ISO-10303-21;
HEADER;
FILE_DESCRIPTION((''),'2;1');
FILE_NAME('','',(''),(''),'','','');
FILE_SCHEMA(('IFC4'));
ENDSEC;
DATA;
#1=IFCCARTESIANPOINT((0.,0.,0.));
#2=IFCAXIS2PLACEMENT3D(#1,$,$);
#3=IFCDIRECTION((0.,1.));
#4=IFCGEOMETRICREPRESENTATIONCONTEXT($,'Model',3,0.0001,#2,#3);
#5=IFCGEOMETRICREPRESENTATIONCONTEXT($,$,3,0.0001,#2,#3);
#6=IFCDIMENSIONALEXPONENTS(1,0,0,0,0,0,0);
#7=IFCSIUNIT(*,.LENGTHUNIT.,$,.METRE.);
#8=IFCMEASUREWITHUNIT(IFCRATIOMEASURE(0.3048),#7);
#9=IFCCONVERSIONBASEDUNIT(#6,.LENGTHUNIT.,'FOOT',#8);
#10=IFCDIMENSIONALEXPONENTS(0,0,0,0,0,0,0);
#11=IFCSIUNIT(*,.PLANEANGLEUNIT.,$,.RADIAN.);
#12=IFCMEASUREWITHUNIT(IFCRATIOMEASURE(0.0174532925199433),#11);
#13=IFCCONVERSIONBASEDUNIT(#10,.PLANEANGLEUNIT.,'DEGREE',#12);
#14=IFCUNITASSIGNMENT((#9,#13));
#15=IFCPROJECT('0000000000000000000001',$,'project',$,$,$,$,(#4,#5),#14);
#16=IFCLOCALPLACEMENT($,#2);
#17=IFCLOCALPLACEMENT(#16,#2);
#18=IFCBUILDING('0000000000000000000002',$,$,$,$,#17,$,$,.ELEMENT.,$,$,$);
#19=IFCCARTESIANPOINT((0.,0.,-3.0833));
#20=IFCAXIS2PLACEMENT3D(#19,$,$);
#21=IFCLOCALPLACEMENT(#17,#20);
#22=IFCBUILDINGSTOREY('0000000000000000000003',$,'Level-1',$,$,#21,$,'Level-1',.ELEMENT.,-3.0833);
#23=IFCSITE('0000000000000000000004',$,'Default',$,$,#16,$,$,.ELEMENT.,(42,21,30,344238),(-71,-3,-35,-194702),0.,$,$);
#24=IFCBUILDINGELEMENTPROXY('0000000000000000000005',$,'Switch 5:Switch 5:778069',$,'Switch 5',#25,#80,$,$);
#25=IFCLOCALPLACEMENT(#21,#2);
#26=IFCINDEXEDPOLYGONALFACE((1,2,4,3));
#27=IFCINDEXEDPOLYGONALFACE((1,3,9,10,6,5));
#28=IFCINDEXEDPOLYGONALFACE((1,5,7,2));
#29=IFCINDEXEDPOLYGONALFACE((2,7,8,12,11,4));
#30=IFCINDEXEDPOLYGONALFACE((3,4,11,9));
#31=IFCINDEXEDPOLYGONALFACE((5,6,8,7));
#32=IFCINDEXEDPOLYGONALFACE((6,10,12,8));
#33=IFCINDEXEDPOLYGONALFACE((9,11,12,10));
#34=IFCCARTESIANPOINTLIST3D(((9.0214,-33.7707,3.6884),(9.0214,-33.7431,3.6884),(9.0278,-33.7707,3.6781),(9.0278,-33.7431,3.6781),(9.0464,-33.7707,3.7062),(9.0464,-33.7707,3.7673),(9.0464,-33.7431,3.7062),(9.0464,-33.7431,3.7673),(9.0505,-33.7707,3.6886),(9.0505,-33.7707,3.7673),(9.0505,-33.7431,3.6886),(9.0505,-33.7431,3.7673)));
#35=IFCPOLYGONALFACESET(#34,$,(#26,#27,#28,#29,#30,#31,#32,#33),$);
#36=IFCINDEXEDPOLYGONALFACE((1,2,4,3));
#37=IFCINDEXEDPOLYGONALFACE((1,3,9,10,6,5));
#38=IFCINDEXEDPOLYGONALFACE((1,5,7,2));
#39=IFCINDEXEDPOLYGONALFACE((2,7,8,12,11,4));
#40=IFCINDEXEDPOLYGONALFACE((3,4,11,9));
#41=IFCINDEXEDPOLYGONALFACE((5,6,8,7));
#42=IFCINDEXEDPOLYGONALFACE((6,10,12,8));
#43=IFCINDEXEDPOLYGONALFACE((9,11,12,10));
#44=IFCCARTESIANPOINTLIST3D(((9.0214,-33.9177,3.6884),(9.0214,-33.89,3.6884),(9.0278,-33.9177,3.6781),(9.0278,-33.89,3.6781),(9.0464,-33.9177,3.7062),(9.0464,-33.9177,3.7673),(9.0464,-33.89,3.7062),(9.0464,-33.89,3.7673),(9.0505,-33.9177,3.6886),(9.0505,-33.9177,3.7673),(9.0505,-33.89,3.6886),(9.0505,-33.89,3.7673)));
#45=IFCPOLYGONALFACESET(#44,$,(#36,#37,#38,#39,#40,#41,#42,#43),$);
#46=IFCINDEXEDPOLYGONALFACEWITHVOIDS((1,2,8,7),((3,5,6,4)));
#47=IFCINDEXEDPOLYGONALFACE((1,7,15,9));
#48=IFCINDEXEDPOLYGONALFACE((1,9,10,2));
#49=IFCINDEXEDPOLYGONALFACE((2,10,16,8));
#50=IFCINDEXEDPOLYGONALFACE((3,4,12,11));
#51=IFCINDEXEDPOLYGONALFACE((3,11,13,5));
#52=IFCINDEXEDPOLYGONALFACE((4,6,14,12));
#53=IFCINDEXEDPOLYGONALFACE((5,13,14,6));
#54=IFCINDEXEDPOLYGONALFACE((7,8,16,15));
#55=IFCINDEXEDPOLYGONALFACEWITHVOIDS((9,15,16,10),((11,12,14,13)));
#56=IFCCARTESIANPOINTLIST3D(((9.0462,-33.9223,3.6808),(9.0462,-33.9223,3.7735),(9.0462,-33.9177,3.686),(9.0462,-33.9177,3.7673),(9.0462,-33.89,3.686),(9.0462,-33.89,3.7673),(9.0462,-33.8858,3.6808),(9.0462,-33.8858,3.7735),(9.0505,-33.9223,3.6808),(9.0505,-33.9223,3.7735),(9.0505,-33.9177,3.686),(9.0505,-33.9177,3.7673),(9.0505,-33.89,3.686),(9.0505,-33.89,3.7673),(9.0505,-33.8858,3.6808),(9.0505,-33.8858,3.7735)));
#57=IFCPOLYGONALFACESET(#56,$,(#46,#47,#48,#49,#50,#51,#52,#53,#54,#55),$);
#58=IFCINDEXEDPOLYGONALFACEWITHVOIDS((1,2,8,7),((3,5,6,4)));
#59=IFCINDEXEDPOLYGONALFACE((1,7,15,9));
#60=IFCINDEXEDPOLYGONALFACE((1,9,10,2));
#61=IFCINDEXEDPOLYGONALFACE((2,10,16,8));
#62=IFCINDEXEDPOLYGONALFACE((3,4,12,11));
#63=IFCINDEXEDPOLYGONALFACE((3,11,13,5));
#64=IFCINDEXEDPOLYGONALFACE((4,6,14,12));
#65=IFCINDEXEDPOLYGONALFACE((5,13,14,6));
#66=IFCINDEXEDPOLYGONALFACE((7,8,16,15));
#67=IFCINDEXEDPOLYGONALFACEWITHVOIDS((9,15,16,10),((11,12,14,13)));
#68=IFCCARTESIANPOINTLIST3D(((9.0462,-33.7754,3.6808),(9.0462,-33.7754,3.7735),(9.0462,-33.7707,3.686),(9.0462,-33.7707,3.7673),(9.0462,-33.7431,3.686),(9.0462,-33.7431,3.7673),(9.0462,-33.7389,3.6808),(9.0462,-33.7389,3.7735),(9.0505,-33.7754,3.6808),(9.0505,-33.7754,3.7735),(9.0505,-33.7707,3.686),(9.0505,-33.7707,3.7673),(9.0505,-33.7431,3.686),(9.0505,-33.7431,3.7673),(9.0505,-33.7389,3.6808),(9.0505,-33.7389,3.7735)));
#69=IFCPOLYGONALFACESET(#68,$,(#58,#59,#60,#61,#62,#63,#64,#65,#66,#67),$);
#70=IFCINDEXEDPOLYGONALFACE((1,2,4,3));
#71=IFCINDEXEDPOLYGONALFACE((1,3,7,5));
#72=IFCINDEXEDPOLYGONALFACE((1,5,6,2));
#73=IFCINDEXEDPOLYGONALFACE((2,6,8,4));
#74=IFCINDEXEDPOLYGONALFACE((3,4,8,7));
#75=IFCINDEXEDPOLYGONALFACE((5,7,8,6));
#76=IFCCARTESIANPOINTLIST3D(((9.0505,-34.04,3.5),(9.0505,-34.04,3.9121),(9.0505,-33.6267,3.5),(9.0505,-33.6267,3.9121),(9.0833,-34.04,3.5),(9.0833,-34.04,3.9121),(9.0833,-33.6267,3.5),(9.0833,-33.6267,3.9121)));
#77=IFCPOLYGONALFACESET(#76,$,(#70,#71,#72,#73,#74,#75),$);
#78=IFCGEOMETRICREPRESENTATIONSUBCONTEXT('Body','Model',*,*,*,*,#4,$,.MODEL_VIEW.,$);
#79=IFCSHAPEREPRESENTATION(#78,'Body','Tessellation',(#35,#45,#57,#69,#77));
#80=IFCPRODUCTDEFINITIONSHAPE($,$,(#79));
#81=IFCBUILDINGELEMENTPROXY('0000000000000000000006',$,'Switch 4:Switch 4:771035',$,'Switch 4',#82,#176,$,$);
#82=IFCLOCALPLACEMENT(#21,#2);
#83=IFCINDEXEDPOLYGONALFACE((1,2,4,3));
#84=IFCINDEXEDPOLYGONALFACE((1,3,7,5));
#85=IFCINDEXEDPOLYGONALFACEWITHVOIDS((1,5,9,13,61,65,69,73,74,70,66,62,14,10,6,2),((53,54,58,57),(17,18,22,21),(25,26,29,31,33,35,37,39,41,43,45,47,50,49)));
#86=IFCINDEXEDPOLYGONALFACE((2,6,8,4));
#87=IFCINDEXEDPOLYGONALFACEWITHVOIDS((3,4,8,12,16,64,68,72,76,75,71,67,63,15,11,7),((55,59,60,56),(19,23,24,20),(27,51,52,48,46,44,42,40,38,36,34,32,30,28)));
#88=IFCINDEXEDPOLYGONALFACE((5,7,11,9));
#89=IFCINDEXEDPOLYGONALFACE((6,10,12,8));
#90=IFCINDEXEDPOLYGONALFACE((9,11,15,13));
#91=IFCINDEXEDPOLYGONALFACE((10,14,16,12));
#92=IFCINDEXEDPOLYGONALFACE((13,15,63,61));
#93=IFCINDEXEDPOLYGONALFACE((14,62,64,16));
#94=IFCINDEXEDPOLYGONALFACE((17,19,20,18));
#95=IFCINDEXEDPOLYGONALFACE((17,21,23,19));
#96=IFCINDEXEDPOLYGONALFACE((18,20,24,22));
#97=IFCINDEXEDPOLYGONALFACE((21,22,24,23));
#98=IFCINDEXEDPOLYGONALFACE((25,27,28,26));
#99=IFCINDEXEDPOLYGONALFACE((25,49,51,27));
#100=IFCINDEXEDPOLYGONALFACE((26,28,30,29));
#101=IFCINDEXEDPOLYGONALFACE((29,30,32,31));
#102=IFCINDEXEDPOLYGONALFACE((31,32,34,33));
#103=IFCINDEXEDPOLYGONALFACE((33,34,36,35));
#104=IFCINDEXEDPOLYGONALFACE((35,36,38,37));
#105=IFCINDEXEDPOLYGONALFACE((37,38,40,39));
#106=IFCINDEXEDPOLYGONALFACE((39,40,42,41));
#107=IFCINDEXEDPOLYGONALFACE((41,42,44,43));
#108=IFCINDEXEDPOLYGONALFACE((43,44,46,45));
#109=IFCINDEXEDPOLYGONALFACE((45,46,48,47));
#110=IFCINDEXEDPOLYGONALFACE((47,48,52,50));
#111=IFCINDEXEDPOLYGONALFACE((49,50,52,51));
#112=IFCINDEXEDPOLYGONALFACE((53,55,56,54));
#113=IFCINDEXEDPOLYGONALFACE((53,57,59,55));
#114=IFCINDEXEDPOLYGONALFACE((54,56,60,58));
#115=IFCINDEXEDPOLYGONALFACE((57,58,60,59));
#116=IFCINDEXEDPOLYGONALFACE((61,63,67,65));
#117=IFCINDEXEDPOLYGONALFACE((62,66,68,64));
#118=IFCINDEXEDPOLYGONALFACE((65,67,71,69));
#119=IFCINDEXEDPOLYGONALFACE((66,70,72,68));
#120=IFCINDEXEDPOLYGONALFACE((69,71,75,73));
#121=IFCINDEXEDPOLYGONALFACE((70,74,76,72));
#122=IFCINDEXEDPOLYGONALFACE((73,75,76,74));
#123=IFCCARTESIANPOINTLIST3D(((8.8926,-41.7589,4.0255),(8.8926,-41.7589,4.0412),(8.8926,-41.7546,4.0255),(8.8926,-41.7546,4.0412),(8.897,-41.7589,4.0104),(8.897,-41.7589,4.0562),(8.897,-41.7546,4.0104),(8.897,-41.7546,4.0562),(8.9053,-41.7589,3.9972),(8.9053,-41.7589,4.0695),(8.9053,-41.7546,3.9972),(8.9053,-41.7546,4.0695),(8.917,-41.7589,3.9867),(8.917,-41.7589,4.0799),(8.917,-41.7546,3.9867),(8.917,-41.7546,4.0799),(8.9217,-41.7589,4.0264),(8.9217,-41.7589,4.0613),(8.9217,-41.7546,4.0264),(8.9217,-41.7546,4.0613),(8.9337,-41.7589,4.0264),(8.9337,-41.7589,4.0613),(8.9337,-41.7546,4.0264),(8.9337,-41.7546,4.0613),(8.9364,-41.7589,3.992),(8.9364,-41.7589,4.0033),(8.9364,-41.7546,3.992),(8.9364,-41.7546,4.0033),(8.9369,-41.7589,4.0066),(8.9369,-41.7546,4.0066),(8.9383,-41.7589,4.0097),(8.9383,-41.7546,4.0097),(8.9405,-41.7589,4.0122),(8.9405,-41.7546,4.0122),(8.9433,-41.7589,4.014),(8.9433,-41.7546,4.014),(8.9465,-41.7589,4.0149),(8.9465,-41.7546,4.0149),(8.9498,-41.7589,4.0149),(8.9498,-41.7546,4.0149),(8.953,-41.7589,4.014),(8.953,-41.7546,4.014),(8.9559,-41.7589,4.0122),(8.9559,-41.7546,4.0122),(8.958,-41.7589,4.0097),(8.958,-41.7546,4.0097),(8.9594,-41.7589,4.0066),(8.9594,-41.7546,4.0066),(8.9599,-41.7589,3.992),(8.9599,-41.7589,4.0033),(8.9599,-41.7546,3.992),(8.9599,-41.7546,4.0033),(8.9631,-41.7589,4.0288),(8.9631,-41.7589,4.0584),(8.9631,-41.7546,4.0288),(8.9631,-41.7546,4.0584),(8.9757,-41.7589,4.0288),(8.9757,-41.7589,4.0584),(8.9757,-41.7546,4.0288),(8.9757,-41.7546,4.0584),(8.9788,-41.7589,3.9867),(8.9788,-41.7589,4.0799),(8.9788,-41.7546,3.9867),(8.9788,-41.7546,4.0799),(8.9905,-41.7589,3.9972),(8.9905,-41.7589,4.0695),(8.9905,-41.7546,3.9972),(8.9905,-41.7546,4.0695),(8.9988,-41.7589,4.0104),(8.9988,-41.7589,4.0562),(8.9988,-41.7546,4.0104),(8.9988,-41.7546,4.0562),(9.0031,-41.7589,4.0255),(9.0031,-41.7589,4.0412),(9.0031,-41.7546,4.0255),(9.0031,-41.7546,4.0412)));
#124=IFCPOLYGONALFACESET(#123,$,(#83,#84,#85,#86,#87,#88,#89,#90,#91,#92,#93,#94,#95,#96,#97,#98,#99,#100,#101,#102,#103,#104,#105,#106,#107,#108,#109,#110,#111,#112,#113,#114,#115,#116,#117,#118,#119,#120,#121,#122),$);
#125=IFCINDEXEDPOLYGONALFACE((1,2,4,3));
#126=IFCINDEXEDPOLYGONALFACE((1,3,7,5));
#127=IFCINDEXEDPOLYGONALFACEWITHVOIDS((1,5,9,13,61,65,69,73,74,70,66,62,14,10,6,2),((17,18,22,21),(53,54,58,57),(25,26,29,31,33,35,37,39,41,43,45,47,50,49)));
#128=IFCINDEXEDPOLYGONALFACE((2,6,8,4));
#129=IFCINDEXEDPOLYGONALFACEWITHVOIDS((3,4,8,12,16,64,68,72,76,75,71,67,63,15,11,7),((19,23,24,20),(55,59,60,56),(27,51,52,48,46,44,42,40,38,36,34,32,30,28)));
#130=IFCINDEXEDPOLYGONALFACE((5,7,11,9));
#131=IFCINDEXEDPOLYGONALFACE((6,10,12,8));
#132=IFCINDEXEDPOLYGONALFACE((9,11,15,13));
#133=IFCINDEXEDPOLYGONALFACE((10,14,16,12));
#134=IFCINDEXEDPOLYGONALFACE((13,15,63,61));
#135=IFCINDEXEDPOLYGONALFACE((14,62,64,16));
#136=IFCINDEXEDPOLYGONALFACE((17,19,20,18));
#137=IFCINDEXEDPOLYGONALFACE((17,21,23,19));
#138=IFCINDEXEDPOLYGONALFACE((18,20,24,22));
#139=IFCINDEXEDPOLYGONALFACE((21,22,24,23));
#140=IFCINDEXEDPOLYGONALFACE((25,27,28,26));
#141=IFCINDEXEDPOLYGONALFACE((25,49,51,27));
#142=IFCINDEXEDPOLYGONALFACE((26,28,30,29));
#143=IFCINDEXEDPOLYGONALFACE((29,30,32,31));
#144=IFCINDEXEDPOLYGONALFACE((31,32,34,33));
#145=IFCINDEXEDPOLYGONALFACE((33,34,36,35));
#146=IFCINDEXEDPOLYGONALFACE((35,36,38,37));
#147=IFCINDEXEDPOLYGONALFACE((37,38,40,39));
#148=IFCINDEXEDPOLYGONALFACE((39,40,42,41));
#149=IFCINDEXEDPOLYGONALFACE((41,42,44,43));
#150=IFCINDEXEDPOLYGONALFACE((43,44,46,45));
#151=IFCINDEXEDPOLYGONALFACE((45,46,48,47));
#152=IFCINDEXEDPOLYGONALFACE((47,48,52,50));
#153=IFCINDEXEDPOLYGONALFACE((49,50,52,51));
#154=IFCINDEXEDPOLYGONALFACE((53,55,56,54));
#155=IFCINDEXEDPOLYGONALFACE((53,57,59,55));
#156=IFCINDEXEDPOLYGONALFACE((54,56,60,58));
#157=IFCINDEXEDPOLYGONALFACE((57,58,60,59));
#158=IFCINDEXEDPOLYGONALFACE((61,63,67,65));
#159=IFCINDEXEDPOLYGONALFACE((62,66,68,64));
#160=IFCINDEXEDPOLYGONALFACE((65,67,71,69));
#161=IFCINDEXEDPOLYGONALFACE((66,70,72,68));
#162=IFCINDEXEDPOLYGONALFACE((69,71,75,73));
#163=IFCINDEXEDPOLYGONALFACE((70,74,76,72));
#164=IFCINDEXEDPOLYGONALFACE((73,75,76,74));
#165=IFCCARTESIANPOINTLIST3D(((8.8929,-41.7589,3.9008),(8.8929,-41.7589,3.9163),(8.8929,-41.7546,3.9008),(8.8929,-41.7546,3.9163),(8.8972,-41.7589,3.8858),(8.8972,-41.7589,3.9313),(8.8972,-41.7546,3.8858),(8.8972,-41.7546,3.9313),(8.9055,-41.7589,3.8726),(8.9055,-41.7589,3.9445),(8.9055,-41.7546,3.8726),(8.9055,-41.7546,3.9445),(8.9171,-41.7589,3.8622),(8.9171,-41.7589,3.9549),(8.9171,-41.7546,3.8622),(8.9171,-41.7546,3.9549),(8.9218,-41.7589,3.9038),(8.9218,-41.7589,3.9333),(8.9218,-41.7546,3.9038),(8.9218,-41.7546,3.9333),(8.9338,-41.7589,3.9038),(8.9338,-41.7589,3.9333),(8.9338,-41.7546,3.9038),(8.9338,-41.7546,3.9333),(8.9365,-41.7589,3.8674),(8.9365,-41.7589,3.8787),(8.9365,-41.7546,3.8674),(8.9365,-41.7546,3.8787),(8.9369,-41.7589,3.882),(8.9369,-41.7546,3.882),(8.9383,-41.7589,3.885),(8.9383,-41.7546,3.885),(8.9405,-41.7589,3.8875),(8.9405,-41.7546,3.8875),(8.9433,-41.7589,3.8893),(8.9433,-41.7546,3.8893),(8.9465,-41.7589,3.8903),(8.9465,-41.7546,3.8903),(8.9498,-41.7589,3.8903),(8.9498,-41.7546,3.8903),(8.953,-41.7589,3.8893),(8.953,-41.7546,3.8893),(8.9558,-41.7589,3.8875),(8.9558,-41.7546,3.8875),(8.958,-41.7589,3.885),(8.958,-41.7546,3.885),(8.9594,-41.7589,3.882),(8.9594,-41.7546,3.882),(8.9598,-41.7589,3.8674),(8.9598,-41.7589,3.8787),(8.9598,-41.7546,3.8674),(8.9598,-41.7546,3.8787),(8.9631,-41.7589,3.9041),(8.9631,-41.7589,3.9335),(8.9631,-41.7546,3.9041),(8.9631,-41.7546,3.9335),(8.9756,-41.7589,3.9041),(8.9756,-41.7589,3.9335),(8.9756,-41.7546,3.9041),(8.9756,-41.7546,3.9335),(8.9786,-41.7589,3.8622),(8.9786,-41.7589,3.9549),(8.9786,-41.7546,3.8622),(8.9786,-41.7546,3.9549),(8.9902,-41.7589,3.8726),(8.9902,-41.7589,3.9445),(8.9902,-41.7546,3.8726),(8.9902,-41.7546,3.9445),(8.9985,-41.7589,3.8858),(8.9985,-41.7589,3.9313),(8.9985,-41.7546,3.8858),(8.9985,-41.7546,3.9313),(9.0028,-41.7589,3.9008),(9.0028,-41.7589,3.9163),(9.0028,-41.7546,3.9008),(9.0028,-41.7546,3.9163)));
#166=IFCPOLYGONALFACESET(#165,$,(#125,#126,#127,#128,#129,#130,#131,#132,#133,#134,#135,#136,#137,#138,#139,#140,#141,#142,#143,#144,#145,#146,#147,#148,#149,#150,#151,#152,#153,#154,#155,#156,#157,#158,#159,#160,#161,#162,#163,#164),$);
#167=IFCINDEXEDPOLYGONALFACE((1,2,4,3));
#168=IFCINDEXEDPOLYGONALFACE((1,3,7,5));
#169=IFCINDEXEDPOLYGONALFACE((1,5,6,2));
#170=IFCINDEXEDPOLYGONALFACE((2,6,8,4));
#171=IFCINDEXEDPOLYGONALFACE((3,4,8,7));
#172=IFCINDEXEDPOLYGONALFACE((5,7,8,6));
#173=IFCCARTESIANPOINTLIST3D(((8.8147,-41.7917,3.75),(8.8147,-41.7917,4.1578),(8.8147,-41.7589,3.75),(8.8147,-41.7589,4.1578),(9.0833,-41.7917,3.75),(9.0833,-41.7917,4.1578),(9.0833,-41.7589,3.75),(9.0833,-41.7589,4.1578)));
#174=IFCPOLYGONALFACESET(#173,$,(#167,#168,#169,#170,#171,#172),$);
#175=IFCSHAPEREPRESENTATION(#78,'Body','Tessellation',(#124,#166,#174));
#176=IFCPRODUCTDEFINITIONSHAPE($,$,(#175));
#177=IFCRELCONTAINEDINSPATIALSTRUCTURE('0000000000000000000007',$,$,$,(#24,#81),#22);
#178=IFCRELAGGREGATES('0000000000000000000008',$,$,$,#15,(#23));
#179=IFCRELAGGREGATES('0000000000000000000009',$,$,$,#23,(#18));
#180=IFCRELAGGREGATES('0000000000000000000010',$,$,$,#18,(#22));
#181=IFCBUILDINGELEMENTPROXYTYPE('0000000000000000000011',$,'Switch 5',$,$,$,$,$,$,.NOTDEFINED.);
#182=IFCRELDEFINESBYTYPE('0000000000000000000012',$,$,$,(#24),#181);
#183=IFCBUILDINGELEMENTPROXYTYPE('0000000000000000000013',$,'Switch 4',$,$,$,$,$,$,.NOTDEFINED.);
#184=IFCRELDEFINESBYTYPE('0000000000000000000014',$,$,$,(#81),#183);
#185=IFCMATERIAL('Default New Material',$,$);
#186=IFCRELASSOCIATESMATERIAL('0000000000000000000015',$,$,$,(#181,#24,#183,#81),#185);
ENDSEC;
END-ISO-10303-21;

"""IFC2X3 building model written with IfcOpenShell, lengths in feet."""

from ifc_helpers import new_model, entity, si_unit, converted_unit, direction, frame, frame_2d, origin, origin_2d_with_axis, place, context, subcontext, project, spatial, polyline, circle_curve, parameter, trimmed, segment, composite_curve, rectangle, outline, extrude, source, transform, mapped, material, type_object, type_shapes, element, save


model = new_model("IFC2X3")

# Units and contexts
model_context = context("Model", 3, precision=0.0001, world=origin(), true_north=direction((0.0, 1.0)))
context_of_model = context(None, 3, precision=0.0001, world=origin(), true_north=direction((0.0, 1.0)))
body_context = subcontext(model_context, "Body", "Model", "MODEL_VIEW")
ifc_project = project(units=[converted_unit("LENGTHUNIT", "FOOT", entity("IfcRatioMeasure", 0.3048), si_unit("LENGTHUNIT", "METRE"), dimensions=[1, 0, 0, 0, 0, 0, 0]), converted_unit("PLANEANGLEUNIT", "DEGREE", entity("IfcRatioMeasure", 0.0174532925199433), si_unit("PLANEANGLEUNIT", "RADIAN"), dimensions=[0, 0, 0, 0, 0, 0, 0])], contexts=[model_context, context_of_model])

# Site, building, storey
site_placement = place(None, origin())
site = spatial("IfcSite", under=ifc_project, at=site_placement, Name="Default", CompositionType="ELEMENT", RefLatitude=(42, 21, 30, 344238), RefLongitude=(-71, -3, -35, -194702), RefElevation=0.0)
building_placement = place(site_placement, origin())
building = spatial("IfcBuilding", under=site, at=building_placement, CompositionType="ELEMENT")
storey_placement = place(building_placement, frame((0.0, 0.0, -3.0833)))
storey = spatial("IfcBuildingStorey", under=building, at=storey_placement, Name="Level-1", LongName="Level-1", CompositionType="ELEMENT", Elevation=-3.0833)

# Shared definitions
ifc_material_1 = material(Name="Default New Material")

# Building element proxies
building_element_proxy_type_1 = type_object("IfcBuildingElementProxyType", Name="Switch 5", PredefinedType="NOTDEFINED", material=ifc_material_1)
shared_shape_1 = source(origin(), body_context, "Body", "SweptSolid", [
    extrude(outline(polyline([(-0.0255, -0.0308), (-0.0133, -0.0308), (-0.0115, -0.0002), (0.0405, 0.0322), (0.0383, 0.0356), (-0.0285, -0.006), (-0.0255, -0.0308)])), frame((0.0626, 0.0429, 0.216), z_axis=(1.0, 0.0, 0.0), x_axis=(0.0, 0.528865, 0.848706)), (0.0, 0.0, 1.0), 0.0277),
    extrude(outline(polyline([(-0.0255, -0.0308), (-0.0133, -0.0308), (-0.0115, -0.0002), (0.0405, 0.0322), (0.0383, 0.0356), (-0.0285, -0.006), (-0.0255, -0.0308)])), frame((-0.0843, 0.0429, 0.216), z_axis=(1.0, 0.0, 0.0), x_axis=(0.0, 0.528865, 0.848706)), (0.0, 0.0, 1.0), 0.0277),
    extrude(outline(polyline([(-0.0464, -0.0182), (0.0464, -0.0182), (0.0464, 0.0182), (-0.0464, 0.0182), (-0.0464, -0.0182)]), holes=[polyline([(-0.0402, -0.0141), (-0.0402, 0.0136), (0.0411, 0.0136), (0.0411, -0.0141), (-0.0402, -0.0141)])]), frame((-0.0707, 0.0329, 0.2271), z_axis=(0.0, 1.0, 0.0), x_axis=(0.0, 0.0, -1.0)), (0.0, 0.0, 1.0), 0.0042),
    extrude(outline(polyline([(-0.0464, -0.0182), (0.0464, -0.0182), (0.0464, 0.0182), (-0.0464, 0.0182), (-0.0464, -0.0182)]), holes=[polyline([(-0.0402, -0.0141), (-0.0402, 0.0136), (0.0411, 0.0136), (0.0411, -0.0141), (-0.0402, -0.0141)])]), frame((0.0762, 0.0329, 0.2271), z_axis=(0.0, 1.0, 0.0), x_axis=(0.0, 0.0, -1.0)), (0.0, 0.0, 1.0), 0.0042),
    extrude(rectangle(XDim=0.0329, YDim=0.4134, at=origin_2d_with_axis()), frame((0.0, 0.0164, 0.0), z_axis=(0.0, 0.0, 1.0), x_axis=(0.0, -1.0, 0.0)), (0.0, 0.0, 1.0), 0.4121),
])
type_shapes(building_element_proxy_type_1, [shared_shape_1])
proxy_1_placement = place(storey_placement, frame((9.0833, -33.8333, 3.5), z_axis=(0.0, 0.0, 1.0), x_axis=(0.0, 1.0, 0.0)))
element("IfcBuildingElementProxy", 1, at=proxy_1_placement, inside=storey, type_object=building_element_proxy_type_1, material=ifc_material_1, Name="Switch 5:Switch 5:778069", ObjectType="Switch 5", context=body_context, shape_type="MappedRepresentation", body=[
    mapped(shared_shape_1, transform((0.0, 0.0, 0.0), scale=1.0)),
])
building_element_proxy_type_2 = type_object("IfcBuildingElementProxyType", Name="Switch 4", PredefinedType="NOTDEFINED", material=ifc_material_1)
shared_shape_2 = source(origin(), body_context, "Body", "SweptSolid", [
    extrude(outline(composite_curve([segment(polyline([(-0.0309, -0.0466), (0.0309, -0.0466)]), True, "CONTINUOUS"), segment(trimmed(circle_curve(frame_2d((-0.0003, 0.0), x_axis=(-1.0, 0.0)), 0.0561), [parameter(123.794741)], [parameter(236.205259)], True, "PARAMETER"), True, "CONTINUOUS"), segment(polyline([(0.0309, 0.0466), (-0.0309, 0.0466)]), True, "CONTINUOUS"), segment(trimmed(circle_curve(frame_2d((0.0003, 0.0), x_axis=(1.0, 0.0)), 0.0561), [parameter(123.794741)], [parameter(236.205259)], True, "PARAMETER"), True, "CONTINUOUS")], self_intersect=False), holes=[polyline([(0.0142, 0.0279), (0.0262, 0.0279), (0.0262, -0.0069), (0.0142, -0.0069), (0.0142, 0.0279)]), polyline([(-0.0153, 0.025), (-0.0153, -0.0045), (-0.0278, -0.0045), (-0.0278, 0.025), (-0.0153, 0.025)]), composite_curve([segment(polyline([(-0.012, -0.0413), (-0.012, -0.03)]), True, "CONTINUOUS"), segment(trimmed(circle_curve(frame_2d((-0.0003, -0.03), x_axis=(-1.0, 0.0)), 0.0117), [parameter(180.0)], [parameter(0.0)], True, "PARAMETER"), False, "CONTINUOUS"), segment(polyline([(0.0115, -0.03), (0.0115, -0.0413)]), True, "CONTINUOUS"), segment(polyline([(0.0115, -0.0413), (-0.012, -0.0413)]), True, "CONTINUOUS")], self_intersect=False)]), frame((-0.0011, 0.0328, 0.2833), z_axis=(0.0, 1.0, 0.0), x_axis=(-1.0, 0.0, 0.0)), (0.0, 0.0, 1.0), 0.0042),
    extrude(outline(composite_curve([segment(polyline([(-0.0308, -0.0464), (0.0308, -0.0464)]), True, "CONTINUOUS"), segment(trimmed(circle_curve(frame_2d((-0.0003, 0.0), x_axis=(-1.0, 0.0)), 0.0558), [parameter(123.794741)], [parameter(236.205259)], True, "PARAMETER"), True, "CONTINUOUS"), segment(polyline([(0.0308, 0.0464), (-0.0308, 0.0464)]), True, "CONTINUOUS"), segment(trimmed(circle_curve(frame_2d((0.0003, 0.0), x_axis=(1.0, 0.0)), 0.0558), [parameter(123.794741)], [parameter(236.205259)], True, "PARAMETER"), True, "CONTINUOUS")], self_intersect=False), holes=[polyline([(0.0141, 0.0247), (0.026, 0.0247), (0.026, -0.0047), (0.0141, -0.0047), (0.0141, 0.0247)]), polyline([(-0.0152, 0.0249), (-0.0152, -0.0045), (-0.0277, -0.0045), (-0.0277, 0.0249), (-0.0152, 0.0249)]), composite_curve([segment(polyline([(-0.012, -0.0411), (-0.012, -0.0299)]), True, "CONTINUOUS"), segment(trimmed(circle_curve(frame_2d((-0.0003, -0.0299), x_axis=(-1.0, 0.0)), 0.0117), [parameter(180.0)], [parameter(0.0)], True, "PARAMETER"), False, "CONTINUOUS"), segment(polyline([(0.0114, -0.0299), (0.0114, -0.0411)]), True, "CONTINUOUS"), segment(polyline([(0.0114, -0.0411), (-0.012, -0.0411)]), True, "CONTINUOUS")], self_intersect=False)]), frame((-0.0011, 0.0328, 0.1586), z_axis=(0.0, 1.0, 0.0), x_axis=(-1.0, 0.0, 0.0)), (0.0, 0.0, 1.0), 0.0042),
    extrude(rectangle(XDim=0.0328, YDim=0.2687, at=origin_2d_with_axis()), frame((0.0, 0.0164, 0.0), z_axis=(0.0, 0.0, 1.0), x_axis=(0.0, -1.0, 0.0)), (0.0, 0.0, 1.0), 0.4078),
])
type_shapes(building_element_proxy_type_2, [shared_shape_2])
proxy_2_placement = place(storey_placement, frame((8.949, -41.7917, 3.75)))
element("IfcBuildingElementProxy", 2, at=proxy_2_placement, inside=storey, type_object=building_element_proxy_type_2, material=ifc_material_1, Name="Switch 4:Switch 4:771035", ObjectType="Switch 4", context=body_context, shape_type="MappedRepresentation", body=[
    mapped(shared_shape_2, transform((0.0, 0.0, 0.0), scale=1.0)),
])

save(model, "model.ifc")
